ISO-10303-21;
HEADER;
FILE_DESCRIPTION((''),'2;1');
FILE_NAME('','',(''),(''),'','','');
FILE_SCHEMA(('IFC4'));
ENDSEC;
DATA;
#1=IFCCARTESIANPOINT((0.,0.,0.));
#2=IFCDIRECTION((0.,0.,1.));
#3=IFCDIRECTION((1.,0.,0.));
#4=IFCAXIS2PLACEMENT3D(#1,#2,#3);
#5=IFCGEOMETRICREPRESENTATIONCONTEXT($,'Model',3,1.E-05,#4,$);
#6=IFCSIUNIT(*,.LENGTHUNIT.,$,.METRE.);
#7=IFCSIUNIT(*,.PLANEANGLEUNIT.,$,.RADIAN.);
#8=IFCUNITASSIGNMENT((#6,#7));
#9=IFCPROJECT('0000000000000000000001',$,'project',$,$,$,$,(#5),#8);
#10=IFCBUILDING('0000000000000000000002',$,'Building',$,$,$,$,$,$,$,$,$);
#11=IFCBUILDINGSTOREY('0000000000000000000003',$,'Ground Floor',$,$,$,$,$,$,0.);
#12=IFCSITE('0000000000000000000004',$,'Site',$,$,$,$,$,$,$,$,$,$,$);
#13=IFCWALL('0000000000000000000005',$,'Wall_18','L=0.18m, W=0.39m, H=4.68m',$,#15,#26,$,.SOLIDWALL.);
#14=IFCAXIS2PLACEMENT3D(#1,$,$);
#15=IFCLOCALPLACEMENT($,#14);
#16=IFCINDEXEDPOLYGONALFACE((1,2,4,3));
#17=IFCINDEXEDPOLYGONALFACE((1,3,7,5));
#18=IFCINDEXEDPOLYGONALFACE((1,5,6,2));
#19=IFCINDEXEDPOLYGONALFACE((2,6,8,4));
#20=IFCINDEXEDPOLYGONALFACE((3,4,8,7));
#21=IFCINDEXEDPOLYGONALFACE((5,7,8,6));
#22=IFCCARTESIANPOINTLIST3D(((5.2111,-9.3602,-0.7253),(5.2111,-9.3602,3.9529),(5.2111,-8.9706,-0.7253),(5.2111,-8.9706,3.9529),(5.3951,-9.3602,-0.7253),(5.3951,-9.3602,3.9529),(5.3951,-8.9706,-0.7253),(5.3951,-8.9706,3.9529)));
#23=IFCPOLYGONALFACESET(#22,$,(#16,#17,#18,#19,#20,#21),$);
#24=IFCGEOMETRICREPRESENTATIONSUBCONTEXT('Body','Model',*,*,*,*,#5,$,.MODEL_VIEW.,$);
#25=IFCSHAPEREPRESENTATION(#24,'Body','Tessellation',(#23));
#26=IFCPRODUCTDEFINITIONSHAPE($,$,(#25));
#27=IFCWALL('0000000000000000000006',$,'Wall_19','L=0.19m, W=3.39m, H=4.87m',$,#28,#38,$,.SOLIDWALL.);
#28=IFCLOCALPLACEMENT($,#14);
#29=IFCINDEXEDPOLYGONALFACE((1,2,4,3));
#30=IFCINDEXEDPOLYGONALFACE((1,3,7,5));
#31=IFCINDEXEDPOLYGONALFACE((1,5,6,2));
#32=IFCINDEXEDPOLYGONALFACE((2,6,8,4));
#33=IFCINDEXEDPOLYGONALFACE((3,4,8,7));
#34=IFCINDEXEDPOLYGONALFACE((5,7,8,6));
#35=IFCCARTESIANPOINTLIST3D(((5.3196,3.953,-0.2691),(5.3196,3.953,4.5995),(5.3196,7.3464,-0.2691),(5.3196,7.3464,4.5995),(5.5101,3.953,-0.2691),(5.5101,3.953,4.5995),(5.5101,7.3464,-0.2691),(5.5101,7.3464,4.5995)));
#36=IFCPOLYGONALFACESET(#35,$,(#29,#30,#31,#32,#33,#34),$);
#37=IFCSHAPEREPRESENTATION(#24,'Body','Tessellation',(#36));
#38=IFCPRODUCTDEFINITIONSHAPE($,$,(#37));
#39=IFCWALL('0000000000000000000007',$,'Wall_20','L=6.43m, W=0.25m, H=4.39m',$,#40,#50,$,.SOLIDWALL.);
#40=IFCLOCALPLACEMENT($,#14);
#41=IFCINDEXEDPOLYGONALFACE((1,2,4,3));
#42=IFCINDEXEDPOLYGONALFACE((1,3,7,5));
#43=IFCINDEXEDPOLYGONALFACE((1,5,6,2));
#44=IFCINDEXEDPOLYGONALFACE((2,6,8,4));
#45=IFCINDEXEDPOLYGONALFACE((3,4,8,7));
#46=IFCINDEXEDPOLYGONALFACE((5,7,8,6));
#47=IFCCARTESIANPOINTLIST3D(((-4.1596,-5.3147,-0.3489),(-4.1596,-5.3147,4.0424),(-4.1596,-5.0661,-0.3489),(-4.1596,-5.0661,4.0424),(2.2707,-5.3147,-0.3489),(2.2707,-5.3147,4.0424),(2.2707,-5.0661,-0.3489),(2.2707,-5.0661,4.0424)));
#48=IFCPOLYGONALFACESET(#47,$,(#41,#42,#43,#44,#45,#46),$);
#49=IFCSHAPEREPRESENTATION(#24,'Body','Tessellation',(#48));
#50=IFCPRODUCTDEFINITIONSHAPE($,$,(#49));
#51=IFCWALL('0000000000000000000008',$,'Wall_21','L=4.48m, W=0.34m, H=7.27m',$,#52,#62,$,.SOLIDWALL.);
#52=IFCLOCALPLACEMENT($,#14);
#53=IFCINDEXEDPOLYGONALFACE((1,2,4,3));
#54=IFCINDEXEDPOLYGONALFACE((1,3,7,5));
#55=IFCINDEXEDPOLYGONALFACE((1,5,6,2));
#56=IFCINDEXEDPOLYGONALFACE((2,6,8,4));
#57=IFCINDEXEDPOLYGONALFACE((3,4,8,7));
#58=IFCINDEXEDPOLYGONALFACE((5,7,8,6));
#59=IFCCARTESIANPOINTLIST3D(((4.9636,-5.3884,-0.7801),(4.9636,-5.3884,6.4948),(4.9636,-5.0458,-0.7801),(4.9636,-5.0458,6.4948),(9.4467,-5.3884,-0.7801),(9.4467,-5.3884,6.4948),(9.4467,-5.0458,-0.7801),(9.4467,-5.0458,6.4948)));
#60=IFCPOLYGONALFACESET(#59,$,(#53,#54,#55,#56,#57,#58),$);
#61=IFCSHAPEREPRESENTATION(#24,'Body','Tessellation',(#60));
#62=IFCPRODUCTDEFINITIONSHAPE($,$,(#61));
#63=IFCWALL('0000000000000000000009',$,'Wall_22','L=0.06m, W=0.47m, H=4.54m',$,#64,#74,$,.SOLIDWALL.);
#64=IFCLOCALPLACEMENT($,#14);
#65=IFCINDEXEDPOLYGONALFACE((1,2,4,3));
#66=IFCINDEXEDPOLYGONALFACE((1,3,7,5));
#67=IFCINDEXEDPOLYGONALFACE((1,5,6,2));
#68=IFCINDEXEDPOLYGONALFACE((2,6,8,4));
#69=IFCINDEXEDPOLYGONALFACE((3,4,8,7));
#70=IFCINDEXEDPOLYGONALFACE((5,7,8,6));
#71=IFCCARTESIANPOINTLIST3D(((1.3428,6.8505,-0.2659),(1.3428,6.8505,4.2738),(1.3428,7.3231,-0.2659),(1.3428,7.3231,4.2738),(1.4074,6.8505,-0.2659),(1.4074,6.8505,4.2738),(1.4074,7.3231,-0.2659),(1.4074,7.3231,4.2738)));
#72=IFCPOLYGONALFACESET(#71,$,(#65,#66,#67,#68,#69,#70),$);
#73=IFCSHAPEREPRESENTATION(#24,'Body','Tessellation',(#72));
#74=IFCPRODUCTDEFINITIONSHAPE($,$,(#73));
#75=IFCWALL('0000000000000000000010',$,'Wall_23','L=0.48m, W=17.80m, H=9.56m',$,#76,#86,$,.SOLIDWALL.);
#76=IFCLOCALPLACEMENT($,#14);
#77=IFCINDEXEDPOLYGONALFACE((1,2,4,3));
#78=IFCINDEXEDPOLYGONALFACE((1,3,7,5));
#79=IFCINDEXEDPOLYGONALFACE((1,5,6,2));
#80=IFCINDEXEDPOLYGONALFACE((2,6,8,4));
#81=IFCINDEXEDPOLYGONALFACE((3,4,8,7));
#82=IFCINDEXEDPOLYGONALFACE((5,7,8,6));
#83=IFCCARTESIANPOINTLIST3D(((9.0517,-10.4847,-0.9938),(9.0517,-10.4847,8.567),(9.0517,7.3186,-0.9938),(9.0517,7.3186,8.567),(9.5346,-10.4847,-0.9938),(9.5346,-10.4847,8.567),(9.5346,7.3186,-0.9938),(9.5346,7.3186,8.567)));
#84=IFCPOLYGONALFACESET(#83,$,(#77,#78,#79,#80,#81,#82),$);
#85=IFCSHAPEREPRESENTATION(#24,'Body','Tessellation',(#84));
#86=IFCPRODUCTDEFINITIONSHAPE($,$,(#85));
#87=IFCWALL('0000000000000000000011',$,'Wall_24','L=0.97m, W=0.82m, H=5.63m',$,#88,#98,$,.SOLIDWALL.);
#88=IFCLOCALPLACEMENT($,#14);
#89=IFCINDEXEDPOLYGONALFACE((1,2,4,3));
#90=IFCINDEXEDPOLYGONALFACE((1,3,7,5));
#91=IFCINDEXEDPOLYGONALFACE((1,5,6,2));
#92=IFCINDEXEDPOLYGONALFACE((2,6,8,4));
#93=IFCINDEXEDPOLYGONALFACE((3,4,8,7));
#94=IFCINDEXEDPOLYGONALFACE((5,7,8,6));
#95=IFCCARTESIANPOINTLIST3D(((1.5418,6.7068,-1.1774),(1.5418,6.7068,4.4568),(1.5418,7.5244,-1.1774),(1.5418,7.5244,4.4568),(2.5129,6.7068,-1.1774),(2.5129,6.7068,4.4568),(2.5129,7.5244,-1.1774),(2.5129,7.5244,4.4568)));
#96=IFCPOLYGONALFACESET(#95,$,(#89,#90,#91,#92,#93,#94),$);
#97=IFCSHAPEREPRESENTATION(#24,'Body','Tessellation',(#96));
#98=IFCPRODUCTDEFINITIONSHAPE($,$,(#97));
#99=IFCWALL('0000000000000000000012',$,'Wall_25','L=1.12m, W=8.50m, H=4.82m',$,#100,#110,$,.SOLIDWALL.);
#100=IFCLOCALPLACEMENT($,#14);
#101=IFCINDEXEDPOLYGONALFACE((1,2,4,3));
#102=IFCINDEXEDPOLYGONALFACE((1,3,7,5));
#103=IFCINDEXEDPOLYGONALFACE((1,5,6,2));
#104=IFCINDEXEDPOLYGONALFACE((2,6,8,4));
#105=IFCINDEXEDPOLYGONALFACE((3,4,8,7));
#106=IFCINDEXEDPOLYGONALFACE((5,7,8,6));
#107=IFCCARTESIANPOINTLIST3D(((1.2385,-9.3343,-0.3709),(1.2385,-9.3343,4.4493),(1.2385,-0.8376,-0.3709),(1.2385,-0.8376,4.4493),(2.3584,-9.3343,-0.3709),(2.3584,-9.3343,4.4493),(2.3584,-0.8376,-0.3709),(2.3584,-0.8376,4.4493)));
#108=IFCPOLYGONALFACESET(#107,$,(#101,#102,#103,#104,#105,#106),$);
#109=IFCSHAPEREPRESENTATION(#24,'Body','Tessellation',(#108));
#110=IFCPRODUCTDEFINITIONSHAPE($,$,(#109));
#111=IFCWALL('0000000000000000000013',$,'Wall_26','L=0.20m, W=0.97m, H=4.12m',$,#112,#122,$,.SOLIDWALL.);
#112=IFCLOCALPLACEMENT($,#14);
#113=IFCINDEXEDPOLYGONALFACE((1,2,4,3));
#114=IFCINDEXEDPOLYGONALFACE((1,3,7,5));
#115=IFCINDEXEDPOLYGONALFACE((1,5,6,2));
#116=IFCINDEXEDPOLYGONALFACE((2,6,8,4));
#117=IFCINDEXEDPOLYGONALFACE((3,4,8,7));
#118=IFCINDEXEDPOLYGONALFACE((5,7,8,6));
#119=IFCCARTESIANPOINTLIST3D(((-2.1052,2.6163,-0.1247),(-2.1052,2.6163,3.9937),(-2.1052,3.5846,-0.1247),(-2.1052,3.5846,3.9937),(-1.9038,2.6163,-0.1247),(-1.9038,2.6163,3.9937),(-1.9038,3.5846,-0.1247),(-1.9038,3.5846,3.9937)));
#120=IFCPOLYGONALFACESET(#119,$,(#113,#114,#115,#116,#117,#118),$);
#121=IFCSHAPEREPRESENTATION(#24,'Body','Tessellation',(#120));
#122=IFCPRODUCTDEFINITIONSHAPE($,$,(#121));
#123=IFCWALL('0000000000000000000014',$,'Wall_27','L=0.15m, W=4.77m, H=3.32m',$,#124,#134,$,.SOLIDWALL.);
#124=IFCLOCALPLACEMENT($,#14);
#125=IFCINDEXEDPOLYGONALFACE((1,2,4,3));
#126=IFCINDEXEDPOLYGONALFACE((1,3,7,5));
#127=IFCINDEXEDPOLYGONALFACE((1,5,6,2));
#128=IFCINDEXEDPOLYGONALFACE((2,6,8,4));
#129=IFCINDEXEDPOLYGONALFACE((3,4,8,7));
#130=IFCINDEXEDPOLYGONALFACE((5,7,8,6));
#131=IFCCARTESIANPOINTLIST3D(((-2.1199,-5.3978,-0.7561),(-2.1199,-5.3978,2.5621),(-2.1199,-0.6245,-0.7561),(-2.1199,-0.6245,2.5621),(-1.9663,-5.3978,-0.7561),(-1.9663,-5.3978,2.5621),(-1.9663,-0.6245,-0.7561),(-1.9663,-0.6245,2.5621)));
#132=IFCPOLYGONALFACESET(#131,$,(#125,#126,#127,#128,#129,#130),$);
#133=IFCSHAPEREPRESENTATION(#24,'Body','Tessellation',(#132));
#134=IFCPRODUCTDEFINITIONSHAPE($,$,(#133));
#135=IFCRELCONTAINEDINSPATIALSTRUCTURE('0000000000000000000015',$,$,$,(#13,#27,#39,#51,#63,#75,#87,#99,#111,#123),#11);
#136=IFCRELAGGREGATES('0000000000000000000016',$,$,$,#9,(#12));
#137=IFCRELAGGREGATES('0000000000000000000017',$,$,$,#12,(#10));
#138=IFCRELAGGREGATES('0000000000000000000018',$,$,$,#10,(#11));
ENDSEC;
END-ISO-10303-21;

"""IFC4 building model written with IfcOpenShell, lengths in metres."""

from ifc_helpers import new_model, si_unit, frame, origin_with_axes, origin_2d, context, subcontext, project, spatial, rectangle, extrude, element, save


model = new_model("IFC4")

# Units and contexts
model_context = context("Model", 3, precision=1e-05, world=origin_with_axes())
body_context = subcontext(model_context, "Body", "Model", "MODEL_VIEW")
ifc_project = project(units=[si_unit("LENGTHUNIT", "METRE"), si_unit("PLANEANGLEUNIT", "RADIAN")], contexts=[model_context])

# Site, building, storey
site = spatial("IfcSite", under=ifc_project, Name="Site")
building = spatial("IfcBuilding", under=site, Name="Building")
storey = spatial("IfcBuildingStorey", under=building, Name="Ground Floor", Elevation=0.0)

# Walls
element("IfcWall", 1, inside=storey, Name="Wall_18", Description="L=0.18m, W=0.39m, H=4.68m", PredefinedType="SOLIDWALL", context=body_context, shape_type="SweptSolid", body=[
    extrude(rectangle(XDim=0.184, YDim=0.3896, at=origin_2d()), frame((5.3031, -9.1654, -0.7253), z_axis=(0.0, 0.0, 1.0), x_axis=(1.0, 0.0, 0.0)), (0.0, 0.0, 1.0), 4.6782),
])
element("IfcWall", 2, inside=storey, Name="Wall_19", Description="L=0.19m, W=3.39m, H=4.87m", PredefinedType="SOLIDWALL", context=body_context, shape_type="SweptSolid", body=[
    extrude(rectangle(XDim=0.1906, YDim=3.3933, at=origin_2d()), frame((5.4148, 5.6497, -0.2691), z_axis=(0.0, 0.0, 1.0), x_axis=(1.0, 0.0, 0.0)), (0.0, 0.0, 1.0), 4.8686),
])
element("IfcWall", 3, inside=storey, Name="Wall_20", Description="L=6.43m, W=0.25m, H=4.39m", PredefinedType="SOLIDWALL", context=body_context, shape_type="SweptSolid", body=[
    extrude(rectangle(XDim=6.4303, YDim=0.2487, at=origin_2d()), frame((-0.9445, -5.1904, -0.3489), z_axis=(0.0, 0.0, 1.0), x_axis=(1.0, 0.0, 0.0)), (0.0, 0.0, 1.0), 4.3913),
])
element("IfcWall", 4, inside=storey, Name="Wall_21", Description="L=4.48m, W=0.34m, H=7.27m", PredefinedType="SOLIDWALL", context=body_context, shape_type="SweptSolid", body=[
    extrude(rectangle(XDim=4.4831, YDim=0.3426, at=origin_2d()), frame((7.2052, -5.2171, -0.7801), z_axis=(0.0, 0.0, 1.0), x_axis=(1.0, 0.0, 0.0)), (0.0, 0.0, 1.0), 7.2749),
])
element("IfcWall", 5, inside=storey, Name="Wall_22", Description="L=0.06m, W=0.47m, H=4.54m", PredefinedType="SOLIDWALL", context=body_context, shape_type="SweptSolid", body=[
    extrude(rectangle(XDim=0.0646, YDim=0.4726, at=origin_2d()), frame((1.3751, 7.0868, -0.2659), z_axis=(0.0, 0.0, 1.0), x_axis=(1.0, 0.0, 0.0)), (0.0, 0.0, 1.0), 4.5397),
])
element("IfcWall", 6, inside=storey, Name="Wall_23", Description="L=0.48m, W=17.80m, H=9.56m", PredefinedType="SOLIDWALL", context=body_context, shape_type="SweptSolid", body=[
    extrude(rectangle(XDim=0.483, YDim=17.8033, at=origin_2d()), frame((9.2931, -1.5831, -0.9938), z_axis=(0.0, 0.0, 1.0), x_axis=(1.0, 0.0, 0.0)), (0.0, 0.0, 1.0), 9.5608),
])
element("IfcWall", 7, inside=storey, Name="Wall_24", Description="L=0.97m, W=0.82m, H=5.63m", PredefinedType="SOLIDWALL", context=body_context, shape_type="SweptSolid", body=[
    extrude(rectangle(XDim=0.9711, YDim=0.8176, at=origin_2d()), frame((2.0273, 7.1156, -1.1774), z_axis=(0.0, 0.0, 1.0), x_axis=(1.0, 0.0, 0.0)), (0.0, 0.0, 1.0), 5.6342),
])
element("IfcWall", 8, inside=storey, Name="Wall_25", Description="L=1.12m, W=8.50m, H=4.82m", PredefinedType="SOLIDWALL", context=body_context, shape_type="SweptSolid", body=[
    extrude(rectangle(XDim=1.1199, YDim=8.4967, at=origin_2d()), frame((1.7984, -5.086, -0.3709), z_axis=(0.0, 0.0, 1.0), x_axis=(1.0, 0.0, 0.0)), (0.0, 0.0, 1.0), 4.8202),
])
element("IfcWall", 9, inside=storey, Name="Wall_26", Description="L=0.20m, W=0.97m, H=4.12m", PredefinedType="SOLIDWALL", context=body_context, shape_type="SweptSolid", body=[
    extrude(rectangle(XDim=0.2014, YDim=0.9684, at=origin_2d()), frame((-2.0045, 3.1005, -0.1247), z_axis=(0.0, 0.0, 1.0), x_axis=(1.0, 0.0, 0.0)), (0.0, 0.0, 1.0), 4.1184),
])
element("IfcWall", 10, inside=storey, Name="Wall_27", Description="L=0.15m, W=4.77m, H=3.32m", PredefinedType="SOLIDWALL", context=body_context, shape_type="SweptSolid", body=[
    extrude(rectangle(XDim=0.1537, YDim=4.7733, at=origin_2d()), frame((-2.0431, -3.0111, -0.7561), z_axis=(0.0, 0.0, 1.0), x_axis=(1.0, 0.0, 0.0)), (0.0, 0.0, 1.0), 3.3182),
])

save(model, "model.ifc")
